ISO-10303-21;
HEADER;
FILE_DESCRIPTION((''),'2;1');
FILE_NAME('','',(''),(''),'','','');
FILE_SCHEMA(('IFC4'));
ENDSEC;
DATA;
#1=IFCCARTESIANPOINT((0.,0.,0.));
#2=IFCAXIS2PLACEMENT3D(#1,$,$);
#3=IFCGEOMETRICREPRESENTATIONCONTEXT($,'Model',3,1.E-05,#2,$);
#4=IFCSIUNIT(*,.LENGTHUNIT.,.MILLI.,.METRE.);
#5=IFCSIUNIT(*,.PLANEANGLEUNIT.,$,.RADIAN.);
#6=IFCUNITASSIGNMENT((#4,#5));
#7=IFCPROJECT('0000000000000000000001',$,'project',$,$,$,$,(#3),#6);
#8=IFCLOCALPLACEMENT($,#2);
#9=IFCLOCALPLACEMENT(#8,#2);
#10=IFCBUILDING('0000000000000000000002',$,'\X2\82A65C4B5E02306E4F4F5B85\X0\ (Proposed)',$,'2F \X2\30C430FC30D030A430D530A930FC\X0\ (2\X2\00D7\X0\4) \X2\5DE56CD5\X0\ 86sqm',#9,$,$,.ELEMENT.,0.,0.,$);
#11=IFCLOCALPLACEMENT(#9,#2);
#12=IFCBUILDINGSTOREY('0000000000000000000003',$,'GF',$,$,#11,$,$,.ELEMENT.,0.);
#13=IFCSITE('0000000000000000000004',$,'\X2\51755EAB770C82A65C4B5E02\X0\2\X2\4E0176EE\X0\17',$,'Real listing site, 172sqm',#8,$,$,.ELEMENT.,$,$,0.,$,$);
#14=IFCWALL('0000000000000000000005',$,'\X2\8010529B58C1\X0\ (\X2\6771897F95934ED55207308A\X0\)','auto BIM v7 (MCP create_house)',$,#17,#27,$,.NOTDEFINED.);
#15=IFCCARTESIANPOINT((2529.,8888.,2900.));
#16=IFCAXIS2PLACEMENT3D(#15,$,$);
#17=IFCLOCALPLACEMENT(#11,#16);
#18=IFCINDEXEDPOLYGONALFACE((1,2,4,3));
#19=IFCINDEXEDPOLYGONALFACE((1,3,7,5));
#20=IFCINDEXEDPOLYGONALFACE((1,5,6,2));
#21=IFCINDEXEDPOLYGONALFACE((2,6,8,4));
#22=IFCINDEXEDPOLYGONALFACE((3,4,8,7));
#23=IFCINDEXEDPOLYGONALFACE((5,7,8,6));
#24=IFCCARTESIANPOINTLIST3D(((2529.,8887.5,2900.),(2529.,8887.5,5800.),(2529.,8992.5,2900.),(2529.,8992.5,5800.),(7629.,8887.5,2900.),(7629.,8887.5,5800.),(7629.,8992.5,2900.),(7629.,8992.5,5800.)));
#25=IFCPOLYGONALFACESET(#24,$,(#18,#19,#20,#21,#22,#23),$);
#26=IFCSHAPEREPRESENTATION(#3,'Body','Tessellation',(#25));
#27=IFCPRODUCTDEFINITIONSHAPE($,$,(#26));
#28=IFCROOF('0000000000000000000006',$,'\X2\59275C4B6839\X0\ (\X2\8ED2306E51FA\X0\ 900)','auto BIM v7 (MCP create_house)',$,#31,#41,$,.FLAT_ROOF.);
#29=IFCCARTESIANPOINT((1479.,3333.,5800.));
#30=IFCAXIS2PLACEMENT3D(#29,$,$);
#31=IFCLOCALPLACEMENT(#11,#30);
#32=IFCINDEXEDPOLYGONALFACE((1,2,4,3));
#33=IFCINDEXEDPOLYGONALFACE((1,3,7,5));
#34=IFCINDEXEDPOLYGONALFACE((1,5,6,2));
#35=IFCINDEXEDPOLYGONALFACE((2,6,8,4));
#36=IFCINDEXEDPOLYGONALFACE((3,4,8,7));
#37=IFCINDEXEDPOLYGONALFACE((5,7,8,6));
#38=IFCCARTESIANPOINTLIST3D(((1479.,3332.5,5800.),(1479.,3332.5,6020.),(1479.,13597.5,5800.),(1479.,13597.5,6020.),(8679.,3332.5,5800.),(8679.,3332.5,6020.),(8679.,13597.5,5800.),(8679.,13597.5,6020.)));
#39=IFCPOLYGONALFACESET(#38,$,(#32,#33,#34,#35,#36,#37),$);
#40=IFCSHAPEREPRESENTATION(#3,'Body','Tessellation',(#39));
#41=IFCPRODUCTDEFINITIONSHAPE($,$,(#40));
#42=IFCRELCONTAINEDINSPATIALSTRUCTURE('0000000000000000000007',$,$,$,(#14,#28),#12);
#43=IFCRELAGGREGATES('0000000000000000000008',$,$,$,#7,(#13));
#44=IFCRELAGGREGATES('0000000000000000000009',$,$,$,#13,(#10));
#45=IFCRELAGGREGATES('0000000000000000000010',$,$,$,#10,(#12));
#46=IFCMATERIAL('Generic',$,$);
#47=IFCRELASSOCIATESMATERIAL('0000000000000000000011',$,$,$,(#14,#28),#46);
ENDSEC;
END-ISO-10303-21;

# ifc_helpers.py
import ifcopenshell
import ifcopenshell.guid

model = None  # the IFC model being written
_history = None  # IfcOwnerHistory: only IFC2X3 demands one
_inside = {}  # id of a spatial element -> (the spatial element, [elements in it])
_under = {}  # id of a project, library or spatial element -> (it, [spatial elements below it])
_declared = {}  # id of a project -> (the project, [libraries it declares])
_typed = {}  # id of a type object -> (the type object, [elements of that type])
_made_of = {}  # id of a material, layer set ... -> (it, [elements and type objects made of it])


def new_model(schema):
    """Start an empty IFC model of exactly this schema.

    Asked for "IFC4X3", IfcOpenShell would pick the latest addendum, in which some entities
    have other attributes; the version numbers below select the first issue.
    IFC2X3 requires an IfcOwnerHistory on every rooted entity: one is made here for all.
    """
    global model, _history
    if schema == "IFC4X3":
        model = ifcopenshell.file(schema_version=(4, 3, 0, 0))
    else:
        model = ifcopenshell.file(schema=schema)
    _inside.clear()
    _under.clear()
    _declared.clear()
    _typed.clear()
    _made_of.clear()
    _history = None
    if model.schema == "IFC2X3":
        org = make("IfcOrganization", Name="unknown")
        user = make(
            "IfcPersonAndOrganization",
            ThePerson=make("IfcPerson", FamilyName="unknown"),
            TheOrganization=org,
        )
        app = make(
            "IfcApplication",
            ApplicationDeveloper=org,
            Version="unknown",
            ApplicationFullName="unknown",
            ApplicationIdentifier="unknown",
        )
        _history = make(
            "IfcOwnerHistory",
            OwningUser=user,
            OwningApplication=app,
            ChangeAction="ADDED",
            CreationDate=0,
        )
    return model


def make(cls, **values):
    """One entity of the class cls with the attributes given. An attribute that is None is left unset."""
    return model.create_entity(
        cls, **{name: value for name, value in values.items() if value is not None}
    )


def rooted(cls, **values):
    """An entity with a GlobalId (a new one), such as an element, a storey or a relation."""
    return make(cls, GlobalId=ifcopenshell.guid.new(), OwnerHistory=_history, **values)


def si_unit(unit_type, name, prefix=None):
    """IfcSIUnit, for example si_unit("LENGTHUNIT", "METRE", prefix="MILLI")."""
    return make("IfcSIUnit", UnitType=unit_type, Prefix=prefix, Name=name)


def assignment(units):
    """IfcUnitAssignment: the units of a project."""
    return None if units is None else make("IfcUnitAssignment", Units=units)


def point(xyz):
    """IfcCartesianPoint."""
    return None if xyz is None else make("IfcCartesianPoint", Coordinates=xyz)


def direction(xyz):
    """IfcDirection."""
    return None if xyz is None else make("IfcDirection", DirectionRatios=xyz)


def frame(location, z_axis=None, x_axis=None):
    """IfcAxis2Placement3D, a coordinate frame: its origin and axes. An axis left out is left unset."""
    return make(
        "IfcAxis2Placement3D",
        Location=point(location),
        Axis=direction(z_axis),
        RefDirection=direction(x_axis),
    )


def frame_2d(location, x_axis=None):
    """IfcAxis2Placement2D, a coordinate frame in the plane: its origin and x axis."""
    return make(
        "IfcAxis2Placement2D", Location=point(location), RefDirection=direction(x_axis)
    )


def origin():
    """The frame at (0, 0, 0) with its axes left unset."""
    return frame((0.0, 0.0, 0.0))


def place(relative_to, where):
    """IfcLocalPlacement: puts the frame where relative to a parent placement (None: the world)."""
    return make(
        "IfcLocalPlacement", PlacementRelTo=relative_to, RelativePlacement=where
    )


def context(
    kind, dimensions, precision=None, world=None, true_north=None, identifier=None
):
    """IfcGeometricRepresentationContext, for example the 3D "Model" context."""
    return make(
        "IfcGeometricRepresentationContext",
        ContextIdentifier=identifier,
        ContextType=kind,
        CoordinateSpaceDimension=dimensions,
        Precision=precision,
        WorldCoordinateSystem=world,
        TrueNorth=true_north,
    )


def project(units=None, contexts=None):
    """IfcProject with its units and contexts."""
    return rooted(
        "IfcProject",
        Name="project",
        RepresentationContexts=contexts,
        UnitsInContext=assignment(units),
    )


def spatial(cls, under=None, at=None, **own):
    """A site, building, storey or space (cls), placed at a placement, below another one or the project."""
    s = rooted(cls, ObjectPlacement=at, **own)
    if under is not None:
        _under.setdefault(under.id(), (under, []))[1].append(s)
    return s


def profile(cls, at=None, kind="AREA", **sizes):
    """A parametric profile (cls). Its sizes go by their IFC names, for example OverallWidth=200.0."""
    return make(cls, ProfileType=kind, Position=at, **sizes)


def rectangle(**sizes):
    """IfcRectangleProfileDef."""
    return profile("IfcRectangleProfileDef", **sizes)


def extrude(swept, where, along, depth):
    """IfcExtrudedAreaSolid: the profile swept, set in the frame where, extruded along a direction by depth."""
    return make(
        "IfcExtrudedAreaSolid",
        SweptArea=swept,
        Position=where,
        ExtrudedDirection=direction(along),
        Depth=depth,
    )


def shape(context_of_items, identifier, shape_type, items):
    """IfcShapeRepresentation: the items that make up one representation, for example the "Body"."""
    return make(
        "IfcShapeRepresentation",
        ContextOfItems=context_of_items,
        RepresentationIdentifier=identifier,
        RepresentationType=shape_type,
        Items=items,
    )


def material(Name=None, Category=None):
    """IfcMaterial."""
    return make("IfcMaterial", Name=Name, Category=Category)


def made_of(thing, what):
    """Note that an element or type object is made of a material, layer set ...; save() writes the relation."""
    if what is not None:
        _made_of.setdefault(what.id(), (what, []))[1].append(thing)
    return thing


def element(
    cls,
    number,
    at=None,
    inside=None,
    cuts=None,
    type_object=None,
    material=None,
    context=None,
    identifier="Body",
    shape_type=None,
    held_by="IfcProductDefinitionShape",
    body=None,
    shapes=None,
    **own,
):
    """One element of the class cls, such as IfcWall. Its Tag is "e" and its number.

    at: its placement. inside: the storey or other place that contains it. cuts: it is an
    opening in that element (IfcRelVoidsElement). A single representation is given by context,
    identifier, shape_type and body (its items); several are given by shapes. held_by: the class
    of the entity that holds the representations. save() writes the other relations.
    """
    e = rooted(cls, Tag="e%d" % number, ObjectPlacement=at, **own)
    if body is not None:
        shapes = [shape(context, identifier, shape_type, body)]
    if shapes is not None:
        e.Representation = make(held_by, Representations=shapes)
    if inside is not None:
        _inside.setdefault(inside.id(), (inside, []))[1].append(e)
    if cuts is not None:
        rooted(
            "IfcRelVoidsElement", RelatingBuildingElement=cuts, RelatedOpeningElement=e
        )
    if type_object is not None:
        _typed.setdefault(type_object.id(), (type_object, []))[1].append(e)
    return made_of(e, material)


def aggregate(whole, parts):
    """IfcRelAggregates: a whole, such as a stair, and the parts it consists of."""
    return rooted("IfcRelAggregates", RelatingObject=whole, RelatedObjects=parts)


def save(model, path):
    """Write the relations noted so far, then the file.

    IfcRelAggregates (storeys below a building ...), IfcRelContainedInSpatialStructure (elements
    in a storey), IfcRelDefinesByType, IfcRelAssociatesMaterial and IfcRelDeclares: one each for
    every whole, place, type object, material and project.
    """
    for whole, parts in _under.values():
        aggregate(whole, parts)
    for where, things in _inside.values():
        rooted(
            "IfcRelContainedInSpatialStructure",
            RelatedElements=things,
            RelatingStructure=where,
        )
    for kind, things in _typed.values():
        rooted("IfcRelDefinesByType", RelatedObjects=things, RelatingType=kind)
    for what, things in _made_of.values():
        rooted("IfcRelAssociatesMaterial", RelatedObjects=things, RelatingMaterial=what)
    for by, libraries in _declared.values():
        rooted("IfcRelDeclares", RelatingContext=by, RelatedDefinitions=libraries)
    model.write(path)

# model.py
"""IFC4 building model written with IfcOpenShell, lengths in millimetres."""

from ifc_helpers import new_model, si_unit, frame, frame_2d, origin, place, context, project, spatial, rectangle, extrude, material, element, save


model = new_model("IFC4")

# Units and contexts
model_context = context("Model", 3, precision=1e-05, world=origin())
ifc_project = project(units=[si_unit("LENGTHUNIT", "METRE", prefix="MILLI"), si_unit("PLANEANGLEUNIT", "RADIAN")], contexts=[model_context])

# Site, building, storey
site_placement = place(None, origin())
site = spatial("IfcSite", under=ifc_project, at=site_placement, Name="兵庫県芦屋市2丁目17", ObjectType="Real listing site, 172sqm", CompositionType="ELEMENT", RefElevation=0.0)
building_placement = place(site_placement, origin())
building = spatial("IfcBuilding", under=site, at=building_placement, Name="芦屋市の住宅 (Proposed)", ObjectType="2F ツーバイフォー (2×4) 工法 86sqm", CompositionType="ELEMENT", ElevationOfRefHeight=0.0, ElevationOfTerrain=0.0)
storey_placement = place(building_placement, origin())
storey = spatial("IfcBuildingStorey", under=building, at=storey_placement, Name="GF", CompositionType="ELEMENT", Elevation=0.0)

# Shared definitions
ifc_material = material(Name="Generic")

# Wall
wall_1_placement = place(storey_placement, frame((2529.0, 8888.0, 2900.0)))
element("IfcWall", 1, at=wall_1_placement, inside=storey, material=ifc_material, Name="耐力壁 (東西間仕切り)", Description="auto BIM v7 (MCP create_house)", PredefinedType="NOTDEFINED", context=model_context, shape_type="SweptSolid", body=[
    extrude(rectangle(XDim=5100.0, YDim=105.0, at=frame_2d((2550.0, 52.0))), frame((2529.0, 8888.0, 2900.0)), (0.0, 0.0, 1.0), 2900.0),
])

# Roof
roof_placement = place(storey_placement, frame((1479.0, 3333.0, 5800.0)))
element("IfcRoof", 2, at=roof_placement, inside=storey, material=ifc_material, Name="大屋根 (軒の出 900)", Description="auto BIM v7 (MCP create_house)", PredefinedType="FLAT_ROOF", context=model_context, shape_type="SweptSolid", body=[
    extrude(rectangle(XDim=7200.0, YDim=10265.0, at=frame_2d((3600.0, 5132.0))), frame((1479.0, 3333.0, 5800.0)), (0.0, 0.0, 1.0), 220.0),
])

save(model, "model.ifc")
